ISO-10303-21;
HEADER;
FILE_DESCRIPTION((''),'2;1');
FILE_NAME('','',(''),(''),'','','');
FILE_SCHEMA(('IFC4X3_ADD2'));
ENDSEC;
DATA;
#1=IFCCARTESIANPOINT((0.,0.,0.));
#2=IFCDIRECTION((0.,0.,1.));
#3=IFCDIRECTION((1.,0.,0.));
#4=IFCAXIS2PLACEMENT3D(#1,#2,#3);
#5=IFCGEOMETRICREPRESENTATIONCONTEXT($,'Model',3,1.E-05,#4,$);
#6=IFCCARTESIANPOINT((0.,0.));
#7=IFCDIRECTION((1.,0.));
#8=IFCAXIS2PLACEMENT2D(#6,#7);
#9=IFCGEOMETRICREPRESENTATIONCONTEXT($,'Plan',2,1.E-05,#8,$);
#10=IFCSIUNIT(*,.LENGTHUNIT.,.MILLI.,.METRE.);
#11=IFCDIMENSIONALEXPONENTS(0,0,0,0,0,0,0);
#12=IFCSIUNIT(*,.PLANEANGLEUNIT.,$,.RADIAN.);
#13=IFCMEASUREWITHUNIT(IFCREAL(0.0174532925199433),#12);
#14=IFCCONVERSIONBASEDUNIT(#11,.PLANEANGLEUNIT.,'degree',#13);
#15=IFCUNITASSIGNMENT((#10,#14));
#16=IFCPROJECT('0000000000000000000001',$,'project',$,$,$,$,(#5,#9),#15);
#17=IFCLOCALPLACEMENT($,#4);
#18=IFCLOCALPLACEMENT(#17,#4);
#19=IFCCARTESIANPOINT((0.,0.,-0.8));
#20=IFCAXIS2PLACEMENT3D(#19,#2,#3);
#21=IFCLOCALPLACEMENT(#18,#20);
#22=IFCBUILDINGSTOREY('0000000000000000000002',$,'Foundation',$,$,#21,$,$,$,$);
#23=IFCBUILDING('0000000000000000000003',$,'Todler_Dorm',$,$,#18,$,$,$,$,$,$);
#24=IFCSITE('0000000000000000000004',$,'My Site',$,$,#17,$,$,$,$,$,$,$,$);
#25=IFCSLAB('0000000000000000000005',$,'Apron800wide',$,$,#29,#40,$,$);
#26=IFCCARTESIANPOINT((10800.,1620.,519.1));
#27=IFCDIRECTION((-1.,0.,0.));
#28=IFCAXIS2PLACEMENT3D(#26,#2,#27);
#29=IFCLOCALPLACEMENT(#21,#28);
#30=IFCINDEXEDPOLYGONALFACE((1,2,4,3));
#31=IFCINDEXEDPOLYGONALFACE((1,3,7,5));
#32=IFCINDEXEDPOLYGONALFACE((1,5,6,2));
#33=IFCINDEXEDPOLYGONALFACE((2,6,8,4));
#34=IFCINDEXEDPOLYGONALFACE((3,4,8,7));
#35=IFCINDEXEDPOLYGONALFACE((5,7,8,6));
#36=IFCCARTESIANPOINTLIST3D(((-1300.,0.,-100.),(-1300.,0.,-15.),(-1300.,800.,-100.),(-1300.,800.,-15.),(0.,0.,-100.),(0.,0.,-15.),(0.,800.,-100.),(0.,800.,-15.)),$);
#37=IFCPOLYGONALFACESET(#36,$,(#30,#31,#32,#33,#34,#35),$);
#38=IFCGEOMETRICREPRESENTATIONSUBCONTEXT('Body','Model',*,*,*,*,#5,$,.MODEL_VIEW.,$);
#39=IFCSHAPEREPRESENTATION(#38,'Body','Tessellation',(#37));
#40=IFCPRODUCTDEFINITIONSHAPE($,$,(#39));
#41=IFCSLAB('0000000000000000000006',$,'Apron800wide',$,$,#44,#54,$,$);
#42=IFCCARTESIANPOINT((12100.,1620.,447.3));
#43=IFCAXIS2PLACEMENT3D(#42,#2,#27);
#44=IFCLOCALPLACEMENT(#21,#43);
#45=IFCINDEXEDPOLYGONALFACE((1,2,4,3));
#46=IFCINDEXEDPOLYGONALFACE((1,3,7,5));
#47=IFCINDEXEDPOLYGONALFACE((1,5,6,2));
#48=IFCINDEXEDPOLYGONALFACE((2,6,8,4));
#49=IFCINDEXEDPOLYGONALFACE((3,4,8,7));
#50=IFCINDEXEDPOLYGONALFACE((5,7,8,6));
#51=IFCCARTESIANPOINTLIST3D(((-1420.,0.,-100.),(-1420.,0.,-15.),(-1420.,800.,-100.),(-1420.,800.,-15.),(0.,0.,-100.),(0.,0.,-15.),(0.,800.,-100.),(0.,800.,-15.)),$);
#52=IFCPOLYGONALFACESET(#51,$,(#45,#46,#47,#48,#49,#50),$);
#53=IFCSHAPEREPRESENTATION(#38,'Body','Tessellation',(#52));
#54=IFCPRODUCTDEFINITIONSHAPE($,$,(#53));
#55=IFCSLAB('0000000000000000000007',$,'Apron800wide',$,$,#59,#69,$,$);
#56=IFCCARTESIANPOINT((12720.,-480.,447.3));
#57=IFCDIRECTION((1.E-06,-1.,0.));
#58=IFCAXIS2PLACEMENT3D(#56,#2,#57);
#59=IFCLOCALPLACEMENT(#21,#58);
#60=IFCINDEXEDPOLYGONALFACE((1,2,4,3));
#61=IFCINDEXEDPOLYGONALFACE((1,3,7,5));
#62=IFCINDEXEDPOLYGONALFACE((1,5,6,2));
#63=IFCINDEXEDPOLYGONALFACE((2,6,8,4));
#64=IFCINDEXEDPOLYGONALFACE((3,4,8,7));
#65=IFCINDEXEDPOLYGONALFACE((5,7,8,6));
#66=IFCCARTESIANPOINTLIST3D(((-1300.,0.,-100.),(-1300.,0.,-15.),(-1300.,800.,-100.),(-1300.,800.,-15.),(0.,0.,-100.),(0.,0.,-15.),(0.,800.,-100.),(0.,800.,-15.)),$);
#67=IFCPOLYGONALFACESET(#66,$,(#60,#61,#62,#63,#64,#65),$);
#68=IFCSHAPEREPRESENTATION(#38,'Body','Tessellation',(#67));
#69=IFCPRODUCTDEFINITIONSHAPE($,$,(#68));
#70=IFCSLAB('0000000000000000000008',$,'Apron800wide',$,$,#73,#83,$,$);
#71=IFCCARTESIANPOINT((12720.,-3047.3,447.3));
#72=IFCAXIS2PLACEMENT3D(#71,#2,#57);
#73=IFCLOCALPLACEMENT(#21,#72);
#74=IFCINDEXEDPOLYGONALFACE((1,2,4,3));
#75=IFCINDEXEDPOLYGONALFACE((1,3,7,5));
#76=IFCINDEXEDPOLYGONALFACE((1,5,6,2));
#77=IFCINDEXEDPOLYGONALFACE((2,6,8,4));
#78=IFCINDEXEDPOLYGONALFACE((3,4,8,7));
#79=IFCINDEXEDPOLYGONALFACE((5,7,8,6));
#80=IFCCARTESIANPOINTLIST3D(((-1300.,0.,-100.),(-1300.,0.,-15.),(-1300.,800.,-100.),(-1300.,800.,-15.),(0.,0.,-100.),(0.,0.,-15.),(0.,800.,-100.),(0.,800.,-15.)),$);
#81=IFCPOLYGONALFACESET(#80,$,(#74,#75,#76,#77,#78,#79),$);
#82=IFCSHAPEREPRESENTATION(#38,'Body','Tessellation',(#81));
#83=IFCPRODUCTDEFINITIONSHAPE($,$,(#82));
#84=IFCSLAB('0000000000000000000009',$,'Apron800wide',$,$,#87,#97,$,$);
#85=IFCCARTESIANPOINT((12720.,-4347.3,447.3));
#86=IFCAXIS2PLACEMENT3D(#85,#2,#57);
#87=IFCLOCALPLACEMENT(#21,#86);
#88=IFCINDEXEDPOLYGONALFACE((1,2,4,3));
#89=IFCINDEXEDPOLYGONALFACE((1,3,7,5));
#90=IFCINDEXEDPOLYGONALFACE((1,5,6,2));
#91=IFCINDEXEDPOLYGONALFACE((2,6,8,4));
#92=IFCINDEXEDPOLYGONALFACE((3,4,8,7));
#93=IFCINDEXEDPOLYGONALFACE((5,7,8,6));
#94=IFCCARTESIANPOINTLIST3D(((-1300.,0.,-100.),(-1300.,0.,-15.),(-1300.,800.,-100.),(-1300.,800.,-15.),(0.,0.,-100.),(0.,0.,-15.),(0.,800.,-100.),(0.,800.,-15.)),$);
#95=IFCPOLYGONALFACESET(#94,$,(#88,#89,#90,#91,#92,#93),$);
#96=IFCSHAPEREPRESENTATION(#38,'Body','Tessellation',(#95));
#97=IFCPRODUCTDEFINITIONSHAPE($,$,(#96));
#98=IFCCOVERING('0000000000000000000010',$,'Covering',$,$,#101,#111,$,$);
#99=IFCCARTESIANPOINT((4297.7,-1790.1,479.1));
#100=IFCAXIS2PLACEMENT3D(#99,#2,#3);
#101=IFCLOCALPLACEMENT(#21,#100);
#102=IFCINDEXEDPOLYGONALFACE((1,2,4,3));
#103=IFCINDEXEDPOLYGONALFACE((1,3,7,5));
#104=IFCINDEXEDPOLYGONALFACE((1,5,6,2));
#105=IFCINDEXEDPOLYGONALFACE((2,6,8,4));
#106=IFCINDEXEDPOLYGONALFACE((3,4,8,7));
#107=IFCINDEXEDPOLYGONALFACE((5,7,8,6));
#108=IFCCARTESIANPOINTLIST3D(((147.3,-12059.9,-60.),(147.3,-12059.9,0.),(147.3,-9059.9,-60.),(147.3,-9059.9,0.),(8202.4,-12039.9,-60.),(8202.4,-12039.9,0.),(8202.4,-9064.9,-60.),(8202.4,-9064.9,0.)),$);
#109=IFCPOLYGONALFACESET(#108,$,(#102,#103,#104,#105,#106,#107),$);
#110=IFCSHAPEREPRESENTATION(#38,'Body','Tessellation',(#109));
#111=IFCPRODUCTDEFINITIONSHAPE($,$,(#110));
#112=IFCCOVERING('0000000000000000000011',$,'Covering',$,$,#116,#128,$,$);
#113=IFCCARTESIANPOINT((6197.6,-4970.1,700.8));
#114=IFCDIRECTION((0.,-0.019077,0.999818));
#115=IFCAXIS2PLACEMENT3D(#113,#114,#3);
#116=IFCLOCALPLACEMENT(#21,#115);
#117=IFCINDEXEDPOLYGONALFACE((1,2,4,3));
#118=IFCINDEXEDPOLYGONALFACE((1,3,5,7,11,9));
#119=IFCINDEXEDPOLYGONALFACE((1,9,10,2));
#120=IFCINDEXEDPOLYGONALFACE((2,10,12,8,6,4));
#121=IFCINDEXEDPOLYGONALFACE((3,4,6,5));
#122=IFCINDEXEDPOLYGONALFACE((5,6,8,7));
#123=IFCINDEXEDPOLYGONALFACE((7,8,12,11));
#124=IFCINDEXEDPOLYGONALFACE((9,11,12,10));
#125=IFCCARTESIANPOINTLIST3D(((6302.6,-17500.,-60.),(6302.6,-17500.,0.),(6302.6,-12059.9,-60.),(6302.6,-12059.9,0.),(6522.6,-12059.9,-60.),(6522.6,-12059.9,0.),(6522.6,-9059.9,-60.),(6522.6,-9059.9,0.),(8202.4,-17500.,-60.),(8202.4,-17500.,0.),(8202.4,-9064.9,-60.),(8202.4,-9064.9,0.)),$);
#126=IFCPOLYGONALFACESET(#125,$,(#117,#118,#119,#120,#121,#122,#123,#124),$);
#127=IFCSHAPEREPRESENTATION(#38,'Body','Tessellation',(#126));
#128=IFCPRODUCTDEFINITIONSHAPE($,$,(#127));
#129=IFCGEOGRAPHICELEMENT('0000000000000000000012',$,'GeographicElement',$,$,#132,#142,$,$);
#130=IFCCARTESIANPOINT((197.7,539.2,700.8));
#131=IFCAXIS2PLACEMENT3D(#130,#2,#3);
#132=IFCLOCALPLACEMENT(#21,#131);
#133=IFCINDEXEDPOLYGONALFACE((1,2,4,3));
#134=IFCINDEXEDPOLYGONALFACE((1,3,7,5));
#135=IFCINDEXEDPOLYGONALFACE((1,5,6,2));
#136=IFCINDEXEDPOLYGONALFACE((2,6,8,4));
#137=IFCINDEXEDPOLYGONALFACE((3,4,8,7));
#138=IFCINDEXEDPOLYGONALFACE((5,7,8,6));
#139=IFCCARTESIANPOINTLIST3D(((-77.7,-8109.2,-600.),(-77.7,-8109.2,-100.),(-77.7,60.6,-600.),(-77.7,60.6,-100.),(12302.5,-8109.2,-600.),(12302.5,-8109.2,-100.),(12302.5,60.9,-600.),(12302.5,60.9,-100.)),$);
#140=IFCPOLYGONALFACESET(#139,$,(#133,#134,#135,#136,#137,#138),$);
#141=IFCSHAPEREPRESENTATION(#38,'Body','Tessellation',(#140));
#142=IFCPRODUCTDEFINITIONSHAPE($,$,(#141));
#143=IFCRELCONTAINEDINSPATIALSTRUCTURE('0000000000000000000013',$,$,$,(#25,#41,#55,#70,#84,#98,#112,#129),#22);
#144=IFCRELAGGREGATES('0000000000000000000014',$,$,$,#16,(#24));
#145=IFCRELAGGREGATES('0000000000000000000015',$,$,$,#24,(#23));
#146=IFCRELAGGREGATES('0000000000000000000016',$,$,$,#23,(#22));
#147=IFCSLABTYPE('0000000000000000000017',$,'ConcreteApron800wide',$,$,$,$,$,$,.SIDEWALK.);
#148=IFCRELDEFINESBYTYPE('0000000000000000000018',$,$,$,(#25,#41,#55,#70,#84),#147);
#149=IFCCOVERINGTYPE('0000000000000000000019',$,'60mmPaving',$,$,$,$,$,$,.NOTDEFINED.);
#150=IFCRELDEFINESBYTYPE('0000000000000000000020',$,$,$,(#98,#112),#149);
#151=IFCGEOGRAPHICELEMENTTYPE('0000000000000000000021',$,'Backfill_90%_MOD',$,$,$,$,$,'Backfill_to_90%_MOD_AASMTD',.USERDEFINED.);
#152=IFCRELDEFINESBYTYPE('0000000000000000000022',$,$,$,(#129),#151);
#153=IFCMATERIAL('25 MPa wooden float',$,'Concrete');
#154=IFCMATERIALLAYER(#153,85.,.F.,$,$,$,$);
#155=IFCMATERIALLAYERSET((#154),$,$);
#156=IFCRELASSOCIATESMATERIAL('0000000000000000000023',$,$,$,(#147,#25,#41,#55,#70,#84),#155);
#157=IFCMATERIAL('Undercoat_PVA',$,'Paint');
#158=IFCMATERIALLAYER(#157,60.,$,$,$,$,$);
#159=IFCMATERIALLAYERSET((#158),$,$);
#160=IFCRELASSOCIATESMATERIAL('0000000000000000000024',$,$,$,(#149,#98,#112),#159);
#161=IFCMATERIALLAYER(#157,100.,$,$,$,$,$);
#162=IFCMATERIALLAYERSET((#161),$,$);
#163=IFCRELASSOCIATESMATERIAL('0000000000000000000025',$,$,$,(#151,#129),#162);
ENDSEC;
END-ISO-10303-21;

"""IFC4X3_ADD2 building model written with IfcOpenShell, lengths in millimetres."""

from ifc_helpers import new_model, entity, si_unit, converted_unit, frame, origin_with_axes, origin_2d_with_axis, place, context, subcontext, project, spatial, indexed_curve, outline, extrude, material, layer, layer_set, layer_usage, type_object, element, save


model = new_model("IFC4X3_ADD2")

# Units and contexts
model_context = context("Model", 3, precision=1e-05, world=origin_with_axes())
plan_context = context("Plan", 2, precision=1e-05, world=origin_2d_with_axis())
body_context = subcontext(model_context, "Body", "Model", "MODEL_VIEW")
ifc_project = project(units=[si_unit("LENGTHUNIT", "METRE", prefix="MILLI"), converted_unit("PLANEANGLEUNIT", "degree", entity("IfcReal", 0.0174532925199433), si_unit("PLANEANGLEUNIT", "RADIAN"), dimensions=[0, 0, 0, 0, 0, 0, 0])], contexts=[model_context, plan_context])

# Site, building, storey
site_placement = place(None, origin_with_axes())
site = spatial("IfcSite", under=ifc_project, at=site_placement, Name="My Site")
building_placement = place(site_placement, origin_with_axes())
building = spatial("IfcBuilding", under=site, at=building_placement, Name="Todler_Dorm")
storey_placement = place(building_placement, frame((0.0, 0.0, -0.8), z_axis=(0.0, 0.0, 1.0), x_axis=(1.0, 0.0, 0.0)))
storey = spatial("IfcBuildingStorey", under=building, at=storey_placement, Name="Foundation")

# Shared definitions
ifc_material_1 = material(Name="Undercoat_PVA", Category="Paint")

# Slabs
ifc_material_2 = material(Name="25 MPa wooden float", Category="Concrete")
ifc_layer_1 = layer(ifc_material_2, 85.0, ventilated=False)
ifc_layer_set_1 = layer_set([ifc_layer_1])
slab_type = type_object("IfcSlabType", Name="ConcreteApron800wide", PredefinedType="SIDEWALK", material=ifc_layer_set_1)
ifc_layer_usage_1 = layer_usage(ifc_layer_set_1, "AXIS3", "POSITIVE", -100.0)
slab_1_placement = place(storey_placement, frame((10800.0, 1620.0, 519.1), z_axis=(0.0, 0.0, 1.0), x_axis=(-1.0, 0.0, 0.0)))
element("IfcSlab", 1, at=slab_1_placement, inside=storey, type_object=slab_type, material=ifc_layer_usage_1, Name="Apron800wide", context=body_context, shape_type="SweptSolid", body=[
    extrude(outline(indexed_curve([(0.0, 0.0), (0.0, 800.0), (-1300.0, 800.0), (-1300.0, 0.0), (0.0, 0.0)])), frame((0.0, 0.0, -100.0), z_axis=(0.0, 0.0, 1.0), x_axis=(1.0, 0.0, 0.0)), (0.0, 0.0, 1.0), 85.0),
])
ifc_layer_usage_2 = layer_usage(ifc_layer_set_1, "AXIS3", "POSITIVE", -100.0)
slab_2_placement = place(storey_placement, frame((12100.0, 1620.0, 447.3), z_axis=(0.0, 0.0, 1.0), x_axis=(-1.0, 0.0, 0.0)))
element("IfcSlab", 2, at=slab_2_placement, inside=storey, type_object=slab_type, material=ifc_layer_usage_2, Name="Apron800wide", context=body_context, shape_type="SweptSolid", body=[
    extrude(outline(indexed_curve([(-1420.0, 0.0), (-1420.0, 800.0), (0.0, 800.0), (0.0, 0.0), (-1420.0, 0.0)])), frame((0.0, 0.0, -100.0), z_axis=(0.0, 0.0, 1.0), x_axis=(1.0, 0.0, 0.0)), (0.0, 0.0, 1.0), 85.0),
])
ifc_layer_usage_3 = layer_usage(ifc_layer_set_1, "AXIS3", "POSITIVE", -100.0)
slab_3_placement = place(storey_placement, frame((12720.0, -480.0, 447.3), z_axis=(0.0, 0.0, 1.0), x_axis=(0.000001, -1.0, 0.0)))
element("IfcSlab", 3, at=slab_3_placement, inside=storey, type_object=slab_type, material=ifc_layer_usage_3, Name="Apron800wide", context=body_context, shape_type="SweptSolid", body=[
    extrude(outline(indexed_curve([(0.0, 0.0), (0.0, 800.0), (-1300.0, 800.0), (-1300.0, 0.0), (0.0, 0.0)])), frame((0.0, 0.0, -100.0), z_axis=(0.0, 0.0, 1.0), x_axis=(1.0, 0.0, 0.0)), (0.0, 0.0, 1.0), 85.0),
])
ifc_layer_usage_4 = layer_usage(ifc_layer_set_1, "AXIS3", "POSITIVE", -100.0)
slab_4_placement = place(storey_placement, frame((12720.0, -3047.3, 447.3), z_axis=(0.0, 0.0, 1.0), x_axis=(0.000001, -1.0, 0.0)))
element("IfcSlab", 4, at=slab_4_placement, inside=storey, type_object=slab_type, material=ifc_layer_usage_4, Name="Apron800wide", context=body_context, shape_type="SweptSolid", body=[
    extrude(outline(indexed_curve([(0.0, 0.0), (0.0, 800.0), (-1300.0, 800.0), (-1300.0, 0.0), (0.0, 0.0)])), frame((0.0, 0.0, -100.0), z_axis=(0.0, 0.0, 1.0), x_axis=(1.0, 0.0, 0.0)), (0.0, 0.0, 1.0), 85.0),
])
ifc_layer_usage_5 = layer_usage(ifc_layer_set_1, "AXIS3", "POSITIVE", -100.0)
slab_5_placement = place(storey_placement, frame((12720.0, -4347.3, 447.3), z_axis=(0.0, 0.0, 1.0), x_axis=(0.000001, -1.0, 0.0)))
element("IfcSlab", 5, at=slab_5_placement, inside=storey, type_object=slab_type, material=ifc_layer_usage_5, Name="Apron800wide", context=body_context, shape_type="SweptSolid", body=[
    extrude(outline(indexed_curve([(0.0, 0.0), (0.0, 800.0), (-1300.0, 800.0), (-1300.0, 0.0), (0.0, 0.0)])), frame((0.0, 0.0, -100.0), z_axis=(0.0, 0.0, 1.0), x_axis=(1.0, 0.0, 0.0)), (0.0, 0.0, 1.0), 85.0),
])

# Coverings
ifc_layer_2 = layer(ifc_material_1, 60.0)
ifc_layer_set_2 = layer_set([ifc_layer_2])
covering_type_1 = type_object("IfcCoveringType", Name="60mmPaving", PredefinedType="NOTDEFINED", material=ifc_layer_set_2)
ifc_layer_usage_6 = layer_usage(ifc_layer_set_2, "AXIS3", "POSITIVE", -60.0)
covering_1_placement = place(storey_placement, frame((4297.7, -1790.1, 479.1), z_axis=(0.0, 0.0, 1.0), x_axis=(1.0, 0.0, 0.0)))
element("IfcCovering", 6, at=covering_1_placement, inside=storey, type_object=covering_type_1, material=ifc_layer_usage_6, Name="Covering", context=body_context, shape_type="SweptSolid", body=[
    extrude(outline(indexed_curve([(147.3, -9059.9), (147.3, -12059.9), (8202.4, -12039.9), (8202.4, -9064.9), (147.3, -9059.9)])), frame((0.0, 0.0, -60.0), z_axis=(0.0, 0.0, 1.0), x_axis=(1.0, 0.0, 0.0)), (0.0, 0.0, 1.0), 60.0),
])
ifc_layer_usage_7 = layer_usage(ifc_layer_set_2, "AXIS3", "POSITIVE", -60.0)
covering_2_placement = place(storey_placement, frame((6197.6, -4970.1, 700.8), z_axis=(0.0, -0.019077, 0.999818), x_axis=(1.0, 0.0, 0.0)))
element("IfcCovering", 7, at=covering_2_placement, inside=storey, type_object=covering_type_1, material=ifc_layer_usage_7, Name="Covering", context=body_context, shape_type="SweptSolid", body=[
    extrude(outline(indexed_curve([(6522.6, -12059.9), (6302.6, -12059.9), (6302.6, -17500.0), (8202.4, -17500.0), (8202.4, -9064.9), (6522.6, -9059.9), (6522.6, -12059.9)])), frame((0.0, 0.0, -60.0), z_axis=(0.0, 0.0, 1.0), x_axis=(1.0, 0.0, 0.0)), (0.0, 0.0, 1.0), 60.0),
])

# Geographic element
ifc_layer_3 = layer(ifc_material_1, 100.0)
ifc_layer_set_3 = layer_set([ifc_layer_3])
ifc_layer_usage_8 = layer_usage(ifc_layer_set_3, "AXIS3", "POSITIVE", -100.0)
geographic_element_type = type_object("IfcGeographicElementType", Name="Backfill_90%_MOD", ElementType="Backfill_to_90%_MOD_AASMTD", PredefinedType="USERDEFINED", material=ifc_layer_set_3)
geographic_element_placement = place(storey_placement, frame((197.7, 539.2, 700.8), z_axis=(0.0, 0.0, 1.0), x_axis=(1.0, 0.0, 0.0)))
element("IfcGeographicElement", 8, at=geographic_element_placement, inside=storey, type_object=geographic_element_type, material=ifc_layer_usage_8, Name="GeographicElement", context=body_context, shape_type="SweptSolid", body=[
    extrude(outline(indexed_curve([(-77.7, -8109.2), (12302.5, -8109.2), (12302.5, 60.9), (-77.7, 60.6), (-77.7, -8109.2)])), frame((0.0, 0.0, -600.0), z_axis=(0.0, 0.0, 1.0), x_axis=(1.0, 0.0, 0.0)), (0.0, 0.0, 1.0), 500.0),
])

save(model, "model.ifc")
